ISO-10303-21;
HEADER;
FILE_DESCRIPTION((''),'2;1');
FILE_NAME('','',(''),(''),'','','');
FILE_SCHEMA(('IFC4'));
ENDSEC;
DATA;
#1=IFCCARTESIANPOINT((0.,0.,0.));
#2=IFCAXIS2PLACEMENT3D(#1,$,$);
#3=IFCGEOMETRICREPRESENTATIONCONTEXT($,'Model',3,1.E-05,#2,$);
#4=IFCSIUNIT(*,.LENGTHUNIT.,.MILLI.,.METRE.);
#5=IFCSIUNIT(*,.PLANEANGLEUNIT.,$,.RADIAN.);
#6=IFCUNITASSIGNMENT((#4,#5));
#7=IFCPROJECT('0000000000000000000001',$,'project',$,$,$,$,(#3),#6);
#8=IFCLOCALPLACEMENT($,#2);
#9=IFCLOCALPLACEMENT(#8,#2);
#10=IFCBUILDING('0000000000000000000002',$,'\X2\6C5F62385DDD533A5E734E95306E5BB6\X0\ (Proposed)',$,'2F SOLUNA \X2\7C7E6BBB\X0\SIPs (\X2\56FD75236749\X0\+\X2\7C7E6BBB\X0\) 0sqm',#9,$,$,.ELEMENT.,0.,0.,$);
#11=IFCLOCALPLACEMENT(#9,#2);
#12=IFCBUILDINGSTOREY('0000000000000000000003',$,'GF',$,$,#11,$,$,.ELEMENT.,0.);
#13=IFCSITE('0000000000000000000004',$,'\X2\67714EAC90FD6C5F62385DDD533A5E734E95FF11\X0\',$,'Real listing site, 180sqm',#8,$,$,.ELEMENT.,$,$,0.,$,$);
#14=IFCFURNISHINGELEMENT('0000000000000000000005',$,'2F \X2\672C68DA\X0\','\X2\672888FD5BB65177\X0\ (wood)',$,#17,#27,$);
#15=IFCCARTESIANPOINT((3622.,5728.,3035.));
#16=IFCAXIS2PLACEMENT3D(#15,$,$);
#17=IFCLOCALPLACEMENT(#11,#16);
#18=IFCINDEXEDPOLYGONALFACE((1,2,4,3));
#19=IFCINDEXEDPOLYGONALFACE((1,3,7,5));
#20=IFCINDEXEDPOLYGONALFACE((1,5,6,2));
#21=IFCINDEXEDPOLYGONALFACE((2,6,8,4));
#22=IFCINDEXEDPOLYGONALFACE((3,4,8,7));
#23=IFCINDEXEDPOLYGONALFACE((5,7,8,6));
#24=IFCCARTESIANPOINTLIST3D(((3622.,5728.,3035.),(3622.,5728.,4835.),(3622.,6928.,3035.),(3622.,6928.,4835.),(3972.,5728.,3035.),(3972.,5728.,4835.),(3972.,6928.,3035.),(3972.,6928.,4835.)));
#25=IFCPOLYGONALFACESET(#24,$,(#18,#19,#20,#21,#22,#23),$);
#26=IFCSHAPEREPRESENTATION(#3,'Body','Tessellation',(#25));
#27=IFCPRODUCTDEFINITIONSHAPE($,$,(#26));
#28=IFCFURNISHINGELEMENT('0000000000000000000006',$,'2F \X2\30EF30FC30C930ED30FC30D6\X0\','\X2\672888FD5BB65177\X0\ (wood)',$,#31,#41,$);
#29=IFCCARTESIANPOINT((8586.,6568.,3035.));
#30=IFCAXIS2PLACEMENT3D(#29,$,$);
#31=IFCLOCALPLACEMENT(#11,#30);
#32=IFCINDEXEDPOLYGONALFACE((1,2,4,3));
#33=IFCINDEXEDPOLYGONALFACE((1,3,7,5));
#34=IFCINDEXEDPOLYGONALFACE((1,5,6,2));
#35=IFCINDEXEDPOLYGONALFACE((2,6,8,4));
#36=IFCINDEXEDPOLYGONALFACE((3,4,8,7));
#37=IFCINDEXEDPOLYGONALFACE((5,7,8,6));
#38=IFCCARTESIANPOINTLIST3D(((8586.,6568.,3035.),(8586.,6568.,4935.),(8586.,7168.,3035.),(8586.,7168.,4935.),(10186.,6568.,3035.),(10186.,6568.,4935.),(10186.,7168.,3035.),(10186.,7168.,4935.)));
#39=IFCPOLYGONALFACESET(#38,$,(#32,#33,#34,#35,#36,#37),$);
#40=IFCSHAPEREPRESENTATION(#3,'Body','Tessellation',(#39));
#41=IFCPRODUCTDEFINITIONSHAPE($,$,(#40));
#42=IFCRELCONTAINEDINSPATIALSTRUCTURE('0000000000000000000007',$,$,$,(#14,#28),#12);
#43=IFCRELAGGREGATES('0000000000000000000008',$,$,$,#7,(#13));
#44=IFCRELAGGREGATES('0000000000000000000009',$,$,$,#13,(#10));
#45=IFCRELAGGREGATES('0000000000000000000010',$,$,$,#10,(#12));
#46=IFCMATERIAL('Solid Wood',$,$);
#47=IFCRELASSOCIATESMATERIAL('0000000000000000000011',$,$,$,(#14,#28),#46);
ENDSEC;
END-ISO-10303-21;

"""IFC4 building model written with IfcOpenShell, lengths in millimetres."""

from ifc_helpers import new_model, si_unit, frame, frame_2d, origin, place, context, project, spatial, rectangle, extrude, material, element, save


model = new_model("IFC4")

# Units and contexts
model_context = context("Model", 3, precision=1e-05, world=origin())
ifc_project = project(units=[si_unit("LENGTHUNIT", "METRE", prefix="MILLI"), si_unit("PLANEANGLEUNIT", "RADIAN")], contexts=[model_context])

# Site, building, storey
site_placement = place(None, origin())
site = spatial("IfcSite", under=ifc_project, at=site_placement, Name="東京都江戸川区平井１", ObjectType="Real listing site, 180sqm", CompositionType="ELEMENT", RefElevation=0.0)
building_placement = place(site_placement, origin())
building = spatial("IfcBuilding", under=site, at=building_placement, Name="江戸川区平井の家 (Proposed)", ObjectType="2F SOLUNA 籾殻SIPs (国産杉+籾殻) 0sqm", CompositionType="ELEMENT", ElevationOfRefHeight=0.0, ElevationOfTerrain=0.0)
storey_placement = place(building_placement, origin())
storey = spatial("IfcBuildingStorey", under=building, at=storey_placement, Name="GF", CompositionType="ELEMENT", Elevation=0.0)

# Shared definitions
ifc_material_1 = material(Name="Solid Wood")

# Furnishing elements
furnishing_1_placement = place(storey_placement, frame((3622.0, 5728.0, 3035.0)))
element("IfcFurnishingElement", 1, at=furnishing_1_placement, inside=storey, material=ifc_material_1, Name="2F 本棚", Description="木製家具 (wood)", context=model_context, shape_type="SweptSolid", body=[
    extrude(rectangle(XDim=350.0, YDim=1200.0, at=frame_2d((175.0, 600.0))), frame((3622.0, 5728.0, 3035.0)), (0.0, 0.0, 1.0), 1800.0),
])
furnishing_2_placement = place(storey_placement, frame((8586.0, 6568.0, 3035.0)))
element("IfcFurnishingElement", 2, at=furnishing_2_placement, inside=storey, material=ifc_material_1, Name="2F ワードローブ", Description="木製家具 (wood)", context=model_context, shape_type="SweptSolid", body=[
    extrude(rectangle(XDim=1600.0, YDim=600.0, at=frame_2d((800.0, 300.0))), frame((8586.0, 6568.0, 3035.0)), (0.0, 0.0, 1.0), 1900.0),
])

save(model, "model.ifc")
